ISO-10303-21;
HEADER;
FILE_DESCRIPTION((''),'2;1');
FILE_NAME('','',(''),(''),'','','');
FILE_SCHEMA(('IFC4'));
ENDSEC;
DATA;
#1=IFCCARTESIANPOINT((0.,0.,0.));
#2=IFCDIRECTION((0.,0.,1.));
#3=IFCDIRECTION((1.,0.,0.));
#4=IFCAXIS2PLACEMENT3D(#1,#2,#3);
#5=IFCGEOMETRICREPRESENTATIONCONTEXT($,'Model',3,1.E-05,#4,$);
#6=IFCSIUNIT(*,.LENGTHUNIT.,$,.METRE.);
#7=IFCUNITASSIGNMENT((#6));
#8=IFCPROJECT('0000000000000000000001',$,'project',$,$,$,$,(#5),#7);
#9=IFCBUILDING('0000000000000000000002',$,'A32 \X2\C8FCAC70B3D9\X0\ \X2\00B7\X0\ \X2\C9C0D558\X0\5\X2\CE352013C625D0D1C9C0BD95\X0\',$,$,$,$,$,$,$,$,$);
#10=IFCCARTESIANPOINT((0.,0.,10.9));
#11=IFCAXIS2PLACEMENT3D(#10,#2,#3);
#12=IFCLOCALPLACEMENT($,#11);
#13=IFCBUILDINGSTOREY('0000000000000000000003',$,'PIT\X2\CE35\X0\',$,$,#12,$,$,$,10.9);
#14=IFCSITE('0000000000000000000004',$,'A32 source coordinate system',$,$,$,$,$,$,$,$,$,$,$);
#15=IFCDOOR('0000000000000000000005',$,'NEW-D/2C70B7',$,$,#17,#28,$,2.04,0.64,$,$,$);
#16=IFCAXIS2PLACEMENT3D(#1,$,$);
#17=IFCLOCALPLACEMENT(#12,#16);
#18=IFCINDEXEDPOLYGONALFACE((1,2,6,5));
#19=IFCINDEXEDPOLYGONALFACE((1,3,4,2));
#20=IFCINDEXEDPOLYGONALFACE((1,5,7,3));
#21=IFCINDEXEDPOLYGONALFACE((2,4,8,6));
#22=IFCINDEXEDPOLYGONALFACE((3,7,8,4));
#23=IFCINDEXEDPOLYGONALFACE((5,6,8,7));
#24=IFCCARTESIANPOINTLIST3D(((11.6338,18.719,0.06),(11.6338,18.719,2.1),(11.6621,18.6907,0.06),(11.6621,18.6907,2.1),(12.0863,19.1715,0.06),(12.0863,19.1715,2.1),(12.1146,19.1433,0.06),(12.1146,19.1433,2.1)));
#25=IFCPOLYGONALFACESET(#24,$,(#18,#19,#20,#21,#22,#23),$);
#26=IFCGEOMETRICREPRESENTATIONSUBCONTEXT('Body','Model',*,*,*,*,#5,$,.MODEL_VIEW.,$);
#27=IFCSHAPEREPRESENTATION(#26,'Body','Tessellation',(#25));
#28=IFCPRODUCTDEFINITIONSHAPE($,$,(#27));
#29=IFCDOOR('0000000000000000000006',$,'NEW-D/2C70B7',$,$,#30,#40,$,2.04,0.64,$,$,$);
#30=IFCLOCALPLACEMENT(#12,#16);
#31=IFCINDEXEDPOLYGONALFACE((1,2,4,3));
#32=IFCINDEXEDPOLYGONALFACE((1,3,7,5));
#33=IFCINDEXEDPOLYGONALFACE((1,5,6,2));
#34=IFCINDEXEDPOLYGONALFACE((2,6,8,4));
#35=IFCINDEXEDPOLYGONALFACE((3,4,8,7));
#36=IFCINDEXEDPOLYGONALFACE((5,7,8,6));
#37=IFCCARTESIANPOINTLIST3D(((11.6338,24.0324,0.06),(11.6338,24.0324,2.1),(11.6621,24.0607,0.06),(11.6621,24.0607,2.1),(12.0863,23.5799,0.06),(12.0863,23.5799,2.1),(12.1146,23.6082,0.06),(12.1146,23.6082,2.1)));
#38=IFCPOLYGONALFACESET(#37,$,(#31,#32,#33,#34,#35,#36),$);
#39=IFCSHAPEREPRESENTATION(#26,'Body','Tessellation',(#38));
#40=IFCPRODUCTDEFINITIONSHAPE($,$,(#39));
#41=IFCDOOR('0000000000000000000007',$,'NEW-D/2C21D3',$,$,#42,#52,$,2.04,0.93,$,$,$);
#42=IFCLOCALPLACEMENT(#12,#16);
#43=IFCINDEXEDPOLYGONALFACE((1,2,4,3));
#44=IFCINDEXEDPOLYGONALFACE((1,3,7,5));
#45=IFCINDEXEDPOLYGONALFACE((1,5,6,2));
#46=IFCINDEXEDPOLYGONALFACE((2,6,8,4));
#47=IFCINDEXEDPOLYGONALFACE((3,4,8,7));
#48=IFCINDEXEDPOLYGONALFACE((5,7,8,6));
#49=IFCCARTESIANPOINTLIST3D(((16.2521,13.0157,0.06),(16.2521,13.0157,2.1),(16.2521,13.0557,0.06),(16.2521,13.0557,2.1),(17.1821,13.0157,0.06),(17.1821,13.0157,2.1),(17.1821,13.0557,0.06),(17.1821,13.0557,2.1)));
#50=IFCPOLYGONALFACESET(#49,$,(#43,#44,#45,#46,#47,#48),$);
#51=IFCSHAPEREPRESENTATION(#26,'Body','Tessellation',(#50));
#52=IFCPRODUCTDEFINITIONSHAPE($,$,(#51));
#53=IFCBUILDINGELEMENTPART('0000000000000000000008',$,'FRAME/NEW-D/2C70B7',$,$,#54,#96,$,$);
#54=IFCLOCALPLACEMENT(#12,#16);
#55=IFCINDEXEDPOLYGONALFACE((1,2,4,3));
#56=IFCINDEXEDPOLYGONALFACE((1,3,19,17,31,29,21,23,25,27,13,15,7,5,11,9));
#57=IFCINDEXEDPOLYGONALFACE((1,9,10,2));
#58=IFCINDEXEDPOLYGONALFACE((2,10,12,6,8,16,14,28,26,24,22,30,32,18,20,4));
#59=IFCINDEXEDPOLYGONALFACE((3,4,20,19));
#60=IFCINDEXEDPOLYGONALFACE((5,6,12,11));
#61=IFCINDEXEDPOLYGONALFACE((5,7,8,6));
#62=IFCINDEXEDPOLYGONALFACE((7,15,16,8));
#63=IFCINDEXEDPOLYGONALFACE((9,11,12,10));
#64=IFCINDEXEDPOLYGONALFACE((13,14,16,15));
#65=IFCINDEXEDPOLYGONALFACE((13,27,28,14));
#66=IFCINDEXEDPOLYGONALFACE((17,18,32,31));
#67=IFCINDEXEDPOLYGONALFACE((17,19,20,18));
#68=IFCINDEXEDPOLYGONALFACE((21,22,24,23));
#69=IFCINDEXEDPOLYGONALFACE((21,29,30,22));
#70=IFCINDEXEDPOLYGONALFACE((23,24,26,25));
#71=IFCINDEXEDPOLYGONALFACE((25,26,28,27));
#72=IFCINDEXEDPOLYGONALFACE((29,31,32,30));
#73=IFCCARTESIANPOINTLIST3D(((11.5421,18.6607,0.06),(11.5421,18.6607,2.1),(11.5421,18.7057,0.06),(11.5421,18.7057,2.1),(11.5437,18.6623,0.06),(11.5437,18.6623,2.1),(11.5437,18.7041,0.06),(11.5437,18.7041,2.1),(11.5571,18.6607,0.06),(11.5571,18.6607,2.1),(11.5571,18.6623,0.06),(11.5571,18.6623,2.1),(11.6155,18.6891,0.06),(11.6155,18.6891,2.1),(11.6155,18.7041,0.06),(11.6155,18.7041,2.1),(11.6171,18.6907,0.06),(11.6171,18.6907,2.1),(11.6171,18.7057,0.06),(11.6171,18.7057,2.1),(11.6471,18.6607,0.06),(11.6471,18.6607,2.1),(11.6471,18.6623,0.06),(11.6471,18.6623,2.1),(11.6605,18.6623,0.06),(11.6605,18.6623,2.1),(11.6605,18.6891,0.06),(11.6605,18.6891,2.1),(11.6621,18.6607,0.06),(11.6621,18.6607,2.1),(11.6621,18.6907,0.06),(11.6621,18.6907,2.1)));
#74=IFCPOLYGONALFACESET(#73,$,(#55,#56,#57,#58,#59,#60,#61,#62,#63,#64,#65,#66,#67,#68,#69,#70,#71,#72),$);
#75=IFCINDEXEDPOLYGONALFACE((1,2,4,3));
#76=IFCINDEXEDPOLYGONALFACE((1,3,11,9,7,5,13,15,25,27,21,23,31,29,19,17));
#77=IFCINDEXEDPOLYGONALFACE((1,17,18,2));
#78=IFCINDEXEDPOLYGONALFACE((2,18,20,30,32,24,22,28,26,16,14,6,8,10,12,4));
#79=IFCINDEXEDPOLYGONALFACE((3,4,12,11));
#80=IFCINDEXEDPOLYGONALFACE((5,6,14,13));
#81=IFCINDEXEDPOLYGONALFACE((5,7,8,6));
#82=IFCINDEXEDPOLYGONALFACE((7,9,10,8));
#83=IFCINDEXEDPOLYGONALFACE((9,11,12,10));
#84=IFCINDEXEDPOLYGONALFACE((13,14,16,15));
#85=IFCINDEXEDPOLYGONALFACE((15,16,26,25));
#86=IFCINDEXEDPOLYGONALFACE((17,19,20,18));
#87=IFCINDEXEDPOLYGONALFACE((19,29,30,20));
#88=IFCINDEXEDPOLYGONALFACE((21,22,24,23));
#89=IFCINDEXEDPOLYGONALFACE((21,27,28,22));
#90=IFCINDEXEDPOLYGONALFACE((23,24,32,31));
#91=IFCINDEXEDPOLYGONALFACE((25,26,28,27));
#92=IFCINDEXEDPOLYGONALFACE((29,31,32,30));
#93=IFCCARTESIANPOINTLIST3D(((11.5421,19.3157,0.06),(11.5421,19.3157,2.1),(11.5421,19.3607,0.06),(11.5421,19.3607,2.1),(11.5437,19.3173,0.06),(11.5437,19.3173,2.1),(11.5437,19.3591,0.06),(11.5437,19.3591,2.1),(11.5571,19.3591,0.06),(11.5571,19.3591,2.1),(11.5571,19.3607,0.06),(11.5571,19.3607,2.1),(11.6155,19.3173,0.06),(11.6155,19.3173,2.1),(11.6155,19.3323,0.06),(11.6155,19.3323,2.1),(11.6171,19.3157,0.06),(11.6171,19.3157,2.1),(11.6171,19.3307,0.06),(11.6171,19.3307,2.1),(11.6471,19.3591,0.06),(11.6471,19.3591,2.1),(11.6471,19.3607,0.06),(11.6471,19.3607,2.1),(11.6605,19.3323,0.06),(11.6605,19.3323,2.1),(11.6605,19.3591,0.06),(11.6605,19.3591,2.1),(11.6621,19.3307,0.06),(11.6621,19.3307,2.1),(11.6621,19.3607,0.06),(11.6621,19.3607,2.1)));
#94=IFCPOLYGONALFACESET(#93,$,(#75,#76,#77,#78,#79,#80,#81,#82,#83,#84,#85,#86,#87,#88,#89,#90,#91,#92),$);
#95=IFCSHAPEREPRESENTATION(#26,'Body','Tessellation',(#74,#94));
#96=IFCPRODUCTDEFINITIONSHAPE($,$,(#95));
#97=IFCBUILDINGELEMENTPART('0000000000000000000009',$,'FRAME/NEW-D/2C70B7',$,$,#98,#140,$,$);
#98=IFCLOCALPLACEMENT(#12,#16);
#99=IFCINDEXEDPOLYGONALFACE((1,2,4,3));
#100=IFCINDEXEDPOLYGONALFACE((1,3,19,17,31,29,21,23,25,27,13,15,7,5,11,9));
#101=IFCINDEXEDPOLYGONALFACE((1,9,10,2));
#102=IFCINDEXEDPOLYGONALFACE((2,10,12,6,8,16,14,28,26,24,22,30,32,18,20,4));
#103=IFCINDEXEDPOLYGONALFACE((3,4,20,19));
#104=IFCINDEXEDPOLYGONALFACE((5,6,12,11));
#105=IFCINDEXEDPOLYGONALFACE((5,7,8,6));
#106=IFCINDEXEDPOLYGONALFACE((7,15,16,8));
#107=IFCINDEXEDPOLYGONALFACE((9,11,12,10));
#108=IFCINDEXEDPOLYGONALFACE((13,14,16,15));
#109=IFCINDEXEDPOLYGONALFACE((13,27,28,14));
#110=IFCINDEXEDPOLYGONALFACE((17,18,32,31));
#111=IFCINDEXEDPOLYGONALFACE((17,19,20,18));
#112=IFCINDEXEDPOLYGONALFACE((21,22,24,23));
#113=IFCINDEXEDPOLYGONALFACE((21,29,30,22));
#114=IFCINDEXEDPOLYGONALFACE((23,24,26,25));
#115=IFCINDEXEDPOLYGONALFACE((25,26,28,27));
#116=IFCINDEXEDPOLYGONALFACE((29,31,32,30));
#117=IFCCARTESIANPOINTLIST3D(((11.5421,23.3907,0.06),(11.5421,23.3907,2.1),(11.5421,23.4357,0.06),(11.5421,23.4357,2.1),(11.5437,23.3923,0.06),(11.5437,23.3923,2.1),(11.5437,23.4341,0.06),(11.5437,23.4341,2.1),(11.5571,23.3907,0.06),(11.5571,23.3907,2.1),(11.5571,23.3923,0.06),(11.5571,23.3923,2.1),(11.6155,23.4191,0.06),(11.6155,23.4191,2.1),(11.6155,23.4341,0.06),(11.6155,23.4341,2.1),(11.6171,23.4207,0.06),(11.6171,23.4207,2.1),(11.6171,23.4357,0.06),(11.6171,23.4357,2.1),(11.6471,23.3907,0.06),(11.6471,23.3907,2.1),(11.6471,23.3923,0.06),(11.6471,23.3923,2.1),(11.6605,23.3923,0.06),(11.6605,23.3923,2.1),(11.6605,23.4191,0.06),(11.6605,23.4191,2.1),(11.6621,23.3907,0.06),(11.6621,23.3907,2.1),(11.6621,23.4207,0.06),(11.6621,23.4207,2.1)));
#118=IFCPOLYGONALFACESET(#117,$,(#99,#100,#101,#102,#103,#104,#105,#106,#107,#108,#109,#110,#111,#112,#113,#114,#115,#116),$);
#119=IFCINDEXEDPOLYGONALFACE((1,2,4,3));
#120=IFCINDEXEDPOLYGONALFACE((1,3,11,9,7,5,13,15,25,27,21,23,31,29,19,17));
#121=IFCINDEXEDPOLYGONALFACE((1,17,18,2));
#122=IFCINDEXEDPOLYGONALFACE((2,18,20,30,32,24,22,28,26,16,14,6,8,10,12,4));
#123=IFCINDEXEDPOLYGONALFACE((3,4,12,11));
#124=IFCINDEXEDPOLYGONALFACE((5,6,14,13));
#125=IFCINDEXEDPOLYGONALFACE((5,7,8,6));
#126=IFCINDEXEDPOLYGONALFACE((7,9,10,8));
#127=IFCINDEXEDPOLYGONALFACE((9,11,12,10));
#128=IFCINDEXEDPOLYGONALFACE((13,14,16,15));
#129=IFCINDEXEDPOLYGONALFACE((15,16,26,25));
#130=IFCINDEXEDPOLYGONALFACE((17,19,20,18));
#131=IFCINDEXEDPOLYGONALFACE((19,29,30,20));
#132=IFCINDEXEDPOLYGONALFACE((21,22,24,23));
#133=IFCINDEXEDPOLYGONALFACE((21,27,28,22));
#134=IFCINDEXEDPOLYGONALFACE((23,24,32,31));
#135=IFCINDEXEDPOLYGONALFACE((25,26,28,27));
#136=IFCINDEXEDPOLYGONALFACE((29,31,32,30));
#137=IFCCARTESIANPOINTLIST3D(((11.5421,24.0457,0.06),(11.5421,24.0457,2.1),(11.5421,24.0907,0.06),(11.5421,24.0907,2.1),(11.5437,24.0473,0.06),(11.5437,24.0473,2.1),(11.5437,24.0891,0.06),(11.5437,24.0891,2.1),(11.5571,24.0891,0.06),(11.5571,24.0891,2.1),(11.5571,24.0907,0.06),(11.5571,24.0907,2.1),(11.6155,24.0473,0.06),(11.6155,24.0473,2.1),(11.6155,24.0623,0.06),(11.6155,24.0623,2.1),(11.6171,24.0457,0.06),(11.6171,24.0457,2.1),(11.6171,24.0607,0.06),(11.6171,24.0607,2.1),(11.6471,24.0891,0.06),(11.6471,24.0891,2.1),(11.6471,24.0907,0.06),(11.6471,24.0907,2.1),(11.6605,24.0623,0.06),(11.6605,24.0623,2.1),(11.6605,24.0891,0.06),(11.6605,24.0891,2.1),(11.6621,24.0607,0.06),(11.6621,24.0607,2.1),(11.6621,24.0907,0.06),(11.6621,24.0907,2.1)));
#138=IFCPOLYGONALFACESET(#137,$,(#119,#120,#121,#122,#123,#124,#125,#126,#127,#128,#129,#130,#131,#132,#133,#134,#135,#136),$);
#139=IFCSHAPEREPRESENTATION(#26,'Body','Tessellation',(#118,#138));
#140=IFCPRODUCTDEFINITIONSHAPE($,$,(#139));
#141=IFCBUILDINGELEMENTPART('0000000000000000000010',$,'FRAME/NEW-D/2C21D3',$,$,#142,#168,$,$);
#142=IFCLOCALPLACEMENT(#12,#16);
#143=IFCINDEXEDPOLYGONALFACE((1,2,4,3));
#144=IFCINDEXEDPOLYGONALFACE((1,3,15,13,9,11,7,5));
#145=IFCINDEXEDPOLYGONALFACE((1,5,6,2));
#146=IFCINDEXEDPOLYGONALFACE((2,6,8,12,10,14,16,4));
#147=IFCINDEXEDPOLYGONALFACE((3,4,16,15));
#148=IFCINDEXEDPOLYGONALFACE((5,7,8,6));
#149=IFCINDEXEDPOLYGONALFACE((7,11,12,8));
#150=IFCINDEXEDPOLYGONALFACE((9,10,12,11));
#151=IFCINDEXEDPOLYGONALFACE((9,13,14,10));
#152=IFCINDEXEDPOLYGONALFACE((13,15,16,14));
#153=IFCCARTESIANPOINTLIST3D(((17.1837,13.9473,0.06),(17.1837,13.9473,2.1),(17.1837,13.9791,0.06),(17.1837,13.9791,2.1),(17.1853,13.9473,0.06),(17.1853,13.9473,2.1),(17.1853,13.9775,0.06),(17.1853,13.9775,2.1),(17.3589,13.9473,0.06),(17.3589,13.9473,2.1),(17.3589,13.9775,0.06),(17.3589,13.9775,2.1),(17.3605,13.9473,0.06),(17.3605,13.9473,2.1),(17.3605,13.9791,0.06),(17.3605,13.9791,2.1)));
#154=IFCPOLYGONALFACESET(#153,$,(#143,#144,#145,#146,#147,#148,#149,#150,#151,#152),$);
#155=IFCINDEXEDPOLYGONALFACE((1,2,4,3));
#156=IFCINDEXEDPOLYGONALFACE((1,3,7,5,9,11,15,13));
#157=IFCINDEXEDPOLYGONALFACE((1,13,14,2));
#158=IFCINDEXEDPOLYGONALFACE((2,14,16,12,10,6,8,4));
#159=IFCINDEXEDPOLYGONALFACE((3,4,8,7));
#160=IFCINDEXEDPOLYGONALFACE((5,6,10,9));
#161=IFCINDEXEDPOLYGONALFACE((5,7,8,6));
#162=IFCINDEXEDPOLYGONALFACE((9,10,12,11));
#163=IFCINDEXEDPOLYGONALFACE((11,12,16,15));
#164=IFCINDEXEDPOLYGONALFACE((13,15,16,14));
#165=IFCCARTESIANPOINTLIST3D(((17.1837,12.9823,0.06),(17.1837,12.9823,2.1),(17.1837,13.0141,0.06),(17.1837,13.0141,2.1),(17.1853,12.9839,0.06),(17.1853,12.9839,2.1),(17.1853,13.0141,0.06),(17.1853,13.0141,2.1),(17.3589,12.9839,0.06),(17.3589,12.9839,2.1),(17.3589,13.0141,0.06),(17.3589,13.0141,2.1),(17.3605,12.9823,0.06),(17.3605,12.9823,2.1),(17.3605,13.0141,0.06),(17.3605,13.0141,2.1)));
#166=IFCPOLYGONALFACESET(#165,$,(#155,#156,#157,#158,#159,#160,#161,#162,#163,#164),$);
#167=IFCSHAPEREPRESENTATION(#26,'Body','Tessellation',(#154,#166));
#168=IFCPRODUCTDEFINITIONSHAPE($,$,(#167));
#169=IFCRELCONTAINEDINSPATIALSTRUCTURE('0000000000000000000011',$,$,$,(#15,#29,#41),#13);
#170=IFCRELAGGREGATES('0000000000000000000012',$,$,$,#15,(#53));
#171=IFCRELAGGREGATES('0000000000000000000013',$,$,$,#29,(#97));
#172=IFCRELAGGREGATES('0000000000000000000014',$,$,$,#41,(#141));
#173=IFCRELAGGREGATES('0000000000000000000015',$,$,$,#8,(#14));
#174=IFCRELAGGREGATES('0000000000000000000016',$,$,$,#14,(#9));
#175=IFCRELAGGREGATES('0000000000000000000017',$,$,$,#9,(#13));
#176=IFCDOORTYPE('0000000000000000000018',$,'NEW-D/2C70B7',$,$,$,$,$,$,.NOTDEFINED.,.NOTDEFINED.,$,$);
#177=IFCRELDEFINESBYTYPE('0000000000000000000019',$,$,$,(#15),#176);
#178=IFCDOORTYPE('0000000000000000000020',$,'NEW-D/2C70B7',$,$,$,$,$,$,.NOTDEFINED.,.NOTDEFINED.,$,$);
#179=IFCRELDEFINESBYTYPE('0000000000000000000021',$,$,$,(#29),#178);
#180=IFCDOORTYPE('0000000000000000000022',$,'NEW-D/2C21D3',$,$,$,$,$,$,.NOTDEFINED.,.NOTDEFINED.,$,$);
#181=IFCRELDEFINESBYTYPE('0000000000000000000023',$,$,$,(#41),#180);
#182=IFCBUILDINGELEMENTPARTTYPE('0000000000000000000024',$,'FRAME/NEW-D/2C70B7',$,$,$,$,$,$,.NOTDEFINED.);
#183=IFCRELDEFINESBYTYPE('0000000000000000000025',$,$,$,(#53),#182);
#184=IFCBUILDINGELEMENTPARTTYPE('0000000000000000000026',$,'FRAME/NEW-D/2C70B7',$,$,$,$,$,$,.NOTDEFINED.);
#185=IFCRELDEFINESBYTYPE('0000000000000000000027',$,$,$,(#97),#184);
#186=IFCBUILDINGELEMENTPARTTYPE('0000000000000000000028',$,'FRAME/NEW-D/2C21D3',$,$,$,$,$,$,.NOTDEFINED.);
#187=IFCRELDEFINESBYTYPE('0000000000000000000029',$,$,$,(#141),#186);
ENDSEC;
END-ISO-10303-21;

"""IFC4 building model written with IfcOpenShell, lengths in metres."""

from ifc_helpers import new_model, si_unit, frame, origin, origin_with_axes, place, context, subcontext, project, spatial, polyline, outline, extrude, source, transform, mapped, type_object, type_shapes, element, aggregate, save


model = new_model("IFC4")

# Units and contexts
model_context = context("Model", 3, precision=1e-05, world=origin_with_axes())
body_context = subcontext(model_context, "Body", "Model", "MODEL_VIEW")
ifc_project = project(units=[si_unit("LENGTHUNIT", "METRE")], contexts=[model_context])

# Site, building, storey
site = spatial("IfcSite", under=ifc_project, Name="A32 source coordinate system")
building = spatial("IfcBuilding", under=site, Name="A32 주거동 · 지하5층–옥탑지붕")
storey_placement = place(None, frame((0.0, 0.0, 10.9), z_axis=(0.0, 0.0, 1.0), x_axis=(1.0, 0.0, 0.0)))
storey = spatial("IfcBuildingStorey", under=building, at=storey_placement, Name="PIT층", Elevation=10.9)

# Doors
door_type_1 = type_object("IfcDoorType", Name="NEW-D/2C70B7", OperationType="NOTDEFINED", PredefinedType="NOTDEFINED")
shared_shape_1 = source(origin(), body_context, "Body", "SweptSolid", [
    extrude(outline(polyline([(11.6621, 18.6907), (11.6338, 18.719), (12.0863, 19.1715), (12.1146, 19.1433), (11.6621, 18.6907)])), frame((0.0, 0.0, 0.06)), (0.0, 0.0, 1.0), 2.04),
])
type_shapes(door_type_1, [shared_shape_1])
door_1_placement = place(storey_placement, origin_with_axes())
door_1 = element("IfcDoor", 1, at=door_1_placement, inside=storey, type_object=door_type_1, Name="NEW-D/2C70B7", OverallHeight=2.04, OverallWidth=0.64, context=body_context, shape_type="MappedRepresentation", body=[
    mapped(shared_shape_1, transform((0.0, 0.0, 0.0), scale=1.0)),
])
door_type_2 = type_object("IfcDoorType", Name="NEW-D/2C70B7", OperationType="NOTDEFINED", PredefinedType="NOTDEFINED")
shared_shape_2 = source(origin(), body_context, "Body", "SweptSolid", [
    extrude(outline(polyline([(12.0863, 23.5799), (11.6338, 24.0324), (11.6621, 24.0607), (12.1146, 23.6082), (12.0863, 23.5799)])), frame((0.0, 0.0, 0.06)), (0.0, 0.0, 1.0), 2.04),
])
type_shapes(door_type_2, [shared_shape_2])
door_2_placement = place(storey_placement, origin_with_axes())
door_2 = element("IfcDoor", 2, at=door_2_placement, inside=storey, type_object=door_type_2, Name="NEW-D/2C70B7", OverallHeight=2.04, OverallWidth=0.64, context=body_context, shape_type="MappedRepresentation", body=[
    mapped(shared_shape_2, transform((0.0, 0.0, 0.0), scale=1.0)),
])
door_type_3 = type_object("IfcDoorType", Name="NEW-D/2C21D3", OperationType="NOTDEFINED", PredefinedType="NOTDEFINED")
shared_shape_3 = source(origin(), body_context, "Body", "SweptSolid", [
    extrude(outline(polyline([(16.2521, 13.0557), (17.1821, 13.0557), (17.1821, 13.0157), (16.2521, 13.0157), (16.2521, 13.0557)])), frame((0.0, 0.0, 0.06)), (0.0, 0.0, 1.0), 2.04),
])
type_shapes(door_type_3, [shared_shape_3])
door_3_placement = place(storey_placement, origin_with_axes())
door_3 = element("IfcDoor", 3, at=door_3_placement, inside=storey, type_object=door_type_3, Name="NEW-D/2C21D3", OverallHeight=2.04, OverallWidth=0.93, context=body_context, shape_type="MappedRepresentation", body=[
    mapped(shared_shape_3, transform((0.0, 0.0, 0.0), scale=1.0)),
])

# Building element parts
building_element_part_type_1 = type_object("IfcBuildingElementPartType", Name="FRAME/NEW-D/2C70B7", PredefinedType="NOTDEFINED")
shared_shape_4 = source(origin(), body_context, "Body", "SweptSolid", [
    extrude(outline(polyline([(11.6605, 18.6891), (11.6155, 18.6891), (11.6155, 18.7041), (11.5437, 18.7041), (11.5437, 18.6623), (11.5571, 18.6623), (11.5571, 18.6607), (11.5421, 18.6607), (11.5421, 18.7057), (11.6171, 18.7057), (11.6171, 18.6907), (11.6621, 18.6907), (11.6621, 18.6607), (11.6471, 18.6607), (11.6471, 18.6623), (11.6605, 18.6623), (11.6605, 18.6891)])), frame((0.0, 0.0, 0.06)), (0.0, 0.0, 1.0), 2.04),
    extrude(outline(polyline([(11.6621, 19.3607), (11.6621, 19.3307), (11.6171, 19.3307), (11.6171, 19.3157), (11.5421, 19.3157), (11.5421, 19.3607), (11.5571, 19.3607), (11.5571, 19.3591), (11.5437, 19.3591), (11.5437, 19.3173), (11.6155, 19.3173), (11.6155, 19.3323), (11.6605, 19.3323), (11.6605, 19.3591), (11.6471, 19.3591), (11.6471, 19.3607), (11.6621, 19.3607)])), frame((0.0, 0.0, 0.06)), (0.0, 0.0, 1.0), 2.04),
])
type_shapes(building_element_part_type_1, [shared_shape_4])
building_element_part_1_placement = place(door_1_placement, origin_with_axes())
building_element_part_1 = element("IfcBuildingElementPart", 4, at=building_element_part_1_placement, type_object=building_element_part_type_1, Name="FRAME/NEW-D/2C70B7", context=body_context, shape_type="MappedRepresentation", body=[
    mapped(shared_shape_4, transform((0.0, 0.0, 0.0), scale=1.0)),
])
aggregate(door_1, [building_element_part_1])
building_element_part_type_2 = type_object("IfcBuildingElementPartType", Name="FRAME/NEW-D/2C70B7", PredefinedType="NOTDEFINED")
shared_shape_5 = source(origin(), body_context, "Body", "SweptSolid", [
    extrude(outline(polyline([(11.6605, 23.4191), (11.6155, 23.4191), (11.6155, 23.4341), (11.5437, 23.4341), (11.5437, 23.3923), (11.5571, 23.3923), (11.5571, 23.3907), (11.5421, 23.3907), (11.5421, 23.4357), (11.6171, 23.4357), (11.6171, 23.4207), (11.6621, 23.4207), (11.6621, 23.3907), (11.6471, 23.3907), (11.6471, 23.3923), (11.6605, 23.3923), (11.6605, 23.4191)])), frame((0.0, 0.0, 0.06)), (0.0, 0.0, 1.0), 2.04),
    extrude(outline(polyline([(11.6621, 24.0907), (11.6621, 24.0607), (11.6171, 24.0607), (11.6171, 24.0457), (11.5421, 24.0457), (11.5421, 24.0907), (11.5571, 24.0907), (11.5571, 24.0891), (11.5437, 24.0891), (11.5437, 24.0473), (11.6155, 24.0473), (11.6155, 24.0623), (11.6605, 24.0623), (11.6605, 24.0891), (11.6471, 24.0891), (11.6471, 24.0907), (11.6621, 24.0907)])), frame((0.0, 0.0, 0.06)), (0.0, 0.0, 1.0), 2.04),
])
type_shapes(building_element_part_type_2, [shared_shape_5])
building_element_part_2_placement = place(door_2_placement, origin_with_axes())
building_element_part_2 = element("IfcBuildingElementPart", 5, at=building_element_part_2_placement, type_object=building_element_part_type_2, Name="FRAME/NEW-D/2C70B7", context=body_context, shape_type="MappedRepresentation", body=[
    mapped(shared_shape_5, transform((0.0, 0.0, 0.0), scale=1.0)),
])
aggregate(door_2, [building_element_part_2])
building_element_part_type_3 = type_object("IfcBuildingElementPartType", Name="FRAME/NEW-D/2C21D3", PredefinedType="NOTDEFINED")
shared_shape_6 = source(origin(), body_context, "Body", "SweptSolid", [
    extrude(outline(polyline([(17.3605, 13.9791), (17.3605, 13.9473), (17.3589, 13.9473), (17.3589, 13.9775), (17.1853, 13.9775), (17.1853, 13.9473), (17.1837, 13.9473), (17.1837, 13.9791), (17.3605, 13.9791)])), frame((0.0, 0.0, 0.06)), (0.0, 0.0, 1.0), 2.04),
    extrude(outline(polyline([(17.1853, 12.9839), (17.3589, 12.9839), (17.3589, 13.0141), (17.3605, 13.0141), (17.3605, 12.9823), (17.1837, 12.9823), (17.1837, 13.0141), (17.1853, 13.0141), (17.1853, 12.9839)])), frame((0.0, 0.0, 0.06)), (0.0, 0.0, 1.0), 2.04),
])
type_shapes(building_element_part_type_3, [shared_shape_6])
building_element_part_3_placement = place(door_3_placement, origin_with_axes())
building_element_part_3 = element("IfcBuildingElementPart", 6, at=building_element_part_3_placement, type_object=building_element_part_type_3, Name="FRAME/NEW-D/2C21D3", context=body_context, shape_type="MappedRepresentation", body=[
    mapped(shared_shape_6, transform((0.0, 0.0, 0.0), scale=1.0)),
])
aggregate(door_3, [building_element_part_3])

save(model, "model.ifc")
